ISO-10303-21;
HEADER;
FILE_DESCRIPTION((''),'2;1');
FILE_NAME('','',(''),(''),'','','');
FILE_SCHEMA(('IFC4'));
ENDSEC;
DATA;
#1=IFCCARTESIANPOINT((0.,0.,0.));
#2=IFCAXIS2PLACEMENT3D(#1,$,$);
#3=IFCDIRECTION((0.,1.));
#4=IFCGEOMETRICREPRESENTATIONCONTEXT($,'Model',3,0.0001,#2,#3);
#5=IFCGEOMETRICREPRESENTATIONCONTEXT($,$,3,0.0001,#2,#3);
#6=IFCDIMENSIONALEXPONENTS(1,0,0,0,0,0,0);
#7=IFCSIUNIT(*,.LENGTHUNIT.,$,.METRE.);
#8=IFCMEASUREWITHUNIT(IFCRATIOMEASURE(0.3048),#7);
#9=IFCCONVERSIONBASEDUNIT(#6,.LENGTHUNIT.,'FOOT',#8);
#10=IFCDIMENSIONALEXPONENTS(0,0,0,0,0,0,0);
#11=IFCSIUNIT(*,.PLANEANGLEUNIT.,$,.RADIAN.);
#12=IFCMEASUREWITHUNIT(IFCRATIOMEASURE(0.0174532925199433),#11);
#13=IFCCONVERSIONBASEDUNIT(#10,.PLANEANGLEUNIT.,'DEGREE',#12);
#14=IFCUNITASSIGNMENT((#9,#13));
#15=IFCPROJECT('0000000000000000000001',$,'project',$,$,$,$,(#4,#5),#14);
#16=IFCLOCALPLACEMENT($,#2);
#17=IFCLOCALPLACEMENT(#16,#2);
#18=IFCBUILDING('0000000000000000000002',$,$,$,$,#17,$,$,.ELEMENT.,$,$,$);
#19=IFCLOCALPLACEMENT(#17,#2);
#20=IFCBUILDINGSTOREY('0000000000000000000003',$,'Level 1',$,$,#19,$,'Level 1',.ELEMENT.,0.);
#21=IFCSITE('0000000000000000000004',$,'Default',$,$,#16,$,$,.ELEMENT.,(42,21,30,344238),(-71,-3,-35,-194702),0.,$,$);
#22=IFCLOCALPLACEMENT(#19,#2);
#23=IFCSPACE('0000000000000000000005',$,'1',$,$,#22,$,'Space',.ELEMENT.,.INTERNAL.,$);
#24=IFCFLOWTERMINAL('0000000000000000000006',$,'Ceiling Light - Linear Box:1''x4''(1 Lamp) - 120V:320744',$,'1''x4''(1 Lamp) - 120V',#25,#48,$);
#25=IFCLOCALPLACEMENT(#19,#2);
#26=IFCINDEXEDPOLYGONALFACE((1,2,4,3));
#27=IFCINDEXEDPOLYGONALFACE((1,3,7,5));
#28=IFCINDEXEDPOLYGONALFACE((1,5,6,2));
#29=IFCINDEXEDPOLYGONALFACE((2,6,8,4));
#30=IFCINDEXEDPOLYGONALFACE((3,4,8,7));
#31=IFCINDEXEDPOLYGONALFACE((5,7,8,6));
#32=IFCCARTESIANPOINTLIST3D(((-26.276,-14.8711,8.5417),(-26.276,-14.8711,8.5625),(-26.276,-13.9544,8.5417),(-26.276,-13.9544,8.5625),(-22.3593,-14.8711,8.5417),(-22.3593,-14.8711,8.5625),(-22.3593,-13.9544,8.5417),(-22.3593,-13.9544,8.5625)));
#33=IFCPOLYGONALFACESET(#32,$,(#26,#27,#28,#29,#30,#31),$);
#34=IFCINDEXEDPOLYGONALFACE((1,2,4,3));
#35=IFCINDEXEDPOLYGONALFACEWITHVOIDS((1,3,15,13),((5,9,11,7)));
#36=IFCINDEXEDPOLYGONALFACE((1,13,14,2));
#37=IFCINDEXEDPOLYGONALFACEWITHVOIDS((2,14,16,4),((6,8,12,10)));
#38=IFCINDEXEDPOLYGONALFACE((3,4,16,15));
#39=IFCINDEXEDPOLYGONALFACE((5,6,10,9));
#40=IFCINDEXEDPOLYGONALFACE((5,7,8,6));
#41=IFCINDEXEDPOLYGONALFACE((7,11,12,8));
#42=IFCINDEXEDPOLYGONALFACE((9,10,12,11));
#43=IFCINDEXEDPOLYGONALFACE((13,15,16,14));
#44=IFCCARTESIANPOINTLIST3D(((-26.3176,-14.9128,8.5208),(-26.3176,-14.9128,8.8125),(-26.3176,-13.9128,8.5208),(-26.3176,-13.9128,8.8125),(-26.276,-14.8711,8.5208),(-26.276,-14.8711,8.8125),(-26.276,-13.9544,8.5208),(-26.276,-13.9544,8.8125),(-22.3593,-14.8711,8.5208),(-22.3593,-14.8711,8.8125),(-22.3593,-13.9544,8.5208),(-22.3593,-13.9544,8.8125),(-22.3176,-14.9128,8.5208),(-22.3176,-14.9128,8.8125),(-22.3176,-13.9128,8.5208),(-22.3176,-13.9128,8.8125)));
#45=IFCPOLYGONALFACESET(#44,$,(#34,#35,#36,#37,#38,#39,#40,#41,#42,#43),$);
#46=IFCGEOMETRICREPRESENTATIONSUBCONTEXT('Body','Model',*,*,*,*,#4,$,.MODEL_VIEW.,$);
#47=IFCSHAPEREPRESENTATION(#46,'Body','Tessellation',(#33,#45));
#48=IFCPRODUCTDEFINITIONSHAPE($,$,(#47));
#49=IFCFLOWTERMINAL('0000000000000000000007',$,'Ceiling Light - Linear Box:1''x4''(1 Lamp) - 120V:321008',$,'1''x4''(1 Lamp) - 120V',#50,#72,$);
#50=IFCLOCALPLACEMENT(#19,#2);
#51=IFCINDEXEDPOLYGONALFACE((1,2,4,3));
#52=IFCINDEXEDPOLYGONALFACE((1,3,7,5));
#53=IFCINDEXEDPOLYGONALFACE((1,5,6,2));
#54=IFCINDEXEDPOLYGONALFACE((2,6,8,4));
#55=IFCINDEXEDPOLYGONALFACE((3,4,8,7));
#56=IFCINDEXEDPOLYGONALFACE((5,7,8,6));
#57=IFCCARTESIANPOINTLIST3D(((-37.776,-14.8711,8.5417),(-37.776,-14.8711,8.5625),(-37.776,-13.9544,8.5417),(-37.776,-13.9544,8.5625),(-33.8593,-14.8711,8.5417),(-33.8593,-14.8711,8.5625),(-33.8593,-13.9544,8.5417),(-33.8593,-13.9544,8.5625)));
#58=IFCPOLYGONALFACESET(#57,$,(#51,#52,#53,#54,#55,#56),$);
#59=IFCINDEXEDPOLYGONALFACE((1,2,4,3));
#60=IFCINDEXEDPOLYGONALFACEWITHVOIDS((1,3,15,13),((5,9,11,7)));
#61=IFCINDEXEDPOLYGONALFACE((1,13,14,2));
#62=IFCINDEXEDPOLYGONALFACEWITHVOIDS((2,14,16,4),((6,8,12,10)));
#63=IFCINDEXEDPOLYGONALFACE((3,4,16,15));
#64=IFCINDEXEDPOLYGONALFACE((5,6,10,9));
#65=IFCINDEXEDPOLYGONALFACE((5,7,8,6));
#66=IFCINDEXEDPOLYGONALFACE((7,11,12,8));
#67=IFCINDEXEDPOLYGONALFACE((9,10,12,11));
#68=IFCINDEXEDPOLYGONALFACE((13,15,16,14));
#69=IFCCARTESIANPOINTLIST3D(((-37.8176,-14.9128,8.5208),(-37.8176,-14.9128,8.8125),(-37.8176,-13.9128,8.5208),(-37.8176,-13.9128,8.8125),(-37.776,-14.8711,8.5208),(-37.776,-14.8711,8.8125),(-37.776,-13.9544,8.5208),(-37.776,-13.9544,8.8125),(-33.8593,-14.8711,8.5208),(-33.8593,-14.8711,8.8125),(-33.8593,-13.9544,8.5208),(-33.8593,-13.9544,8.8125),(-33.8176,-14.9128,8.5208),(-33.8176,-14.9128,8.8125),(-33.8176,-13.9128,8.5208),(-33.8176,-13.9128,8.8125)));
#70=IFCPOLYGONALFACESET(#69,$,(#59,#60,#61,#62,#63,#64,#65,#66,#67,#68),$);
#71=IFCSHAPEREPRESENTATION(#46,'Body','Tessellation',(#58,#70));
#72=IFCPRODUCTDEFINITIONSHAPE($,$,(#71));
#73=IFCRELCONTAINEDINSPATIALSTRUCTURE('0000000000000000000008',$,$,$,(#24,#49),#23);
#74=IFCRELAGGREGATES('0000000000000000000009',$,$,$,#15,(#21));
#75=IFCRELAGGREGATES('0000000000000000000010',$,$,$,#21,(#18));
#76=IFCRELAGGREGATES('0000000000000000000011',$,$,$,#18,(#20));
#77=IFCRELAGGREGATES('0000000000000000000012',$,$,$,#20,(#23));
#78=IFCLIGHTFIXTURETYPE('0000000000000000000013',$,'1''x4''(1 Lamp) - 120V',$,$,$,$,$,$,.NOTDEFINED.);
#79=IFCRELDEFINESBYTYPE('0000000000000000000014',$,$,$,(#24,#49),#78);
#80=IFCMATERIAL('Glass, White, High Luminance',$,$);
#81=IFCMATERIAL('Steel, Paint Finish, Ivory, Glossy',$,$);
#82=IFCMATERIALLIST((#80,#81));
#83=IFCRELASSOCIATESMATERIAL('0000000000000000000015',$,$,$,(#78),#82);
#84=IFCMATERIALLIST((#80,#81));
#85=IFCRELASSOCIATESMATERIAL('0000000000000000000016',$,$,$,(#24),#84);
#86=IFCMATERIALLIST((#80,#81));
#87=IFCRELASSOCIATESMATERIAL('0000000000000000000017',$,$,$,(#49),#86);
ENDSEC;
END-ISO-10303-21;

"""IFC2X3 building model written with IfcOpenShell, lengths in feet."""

from ifc_helpers import new_model, entity, si_unit, converted_unit, direction, frame, origin, origin_2d_with_axis, place, context, subcontext, project, spatial, polyline, rectangle, outline, extrude, source, transform, mapped, material, material_list, type_object, type_shapes, element, save


model = new_model("IFC2X3")

# Units and contexts
model_context = context("Model", 3, precision=0.0001, world=origin(), true_north=direction((0.0, 1.0)))
context_of_model = context(None, 3, precision=0.0001, world=origin(), true_north=direction((0.0, 1.0)))
body_context = subcontext(model_context, "Body", "Model", "MODEL_VIEW")
ifc_project = project(units=[converted_unit("LENGTHUNIT", "FOOT", entity("IfcRatioMeasure", 0.3048), si_unit("LENGTHUNIT", "METRE"), dimensions=[1, 0, 0, 0, 0, 0, 0]), converted_unit("PLANEANGLEUNIT", "DEGREE", entity("IfcRatioMeasure", 0.0174532925199433), si_unit("PLANEANGLEUNIT", "RADIAN"), dimensions=[0, 0, 0, 0, 0, 0, 0])], contexts=[model_context, context_of_model])

# Site, building, storey
site_placement = place(None, origin())
site = spatial("IfcSite", under=ifc_project, at=site_placement, Name="Default", CompositionType="ELEMENT", RefLatitude=(42, 21, 30, 344238), RefLongitude=(-71, -3, -35, -194702), RefElevation=0.0)
building_placement = place(site_placement, origin())
building = spatial("IfcBuilding", under=site, at=building_placement, CompositionType="ELEMENT")
storey_placement = place(building_placement, origin())
storey = spatial("IfcBuildingStorey", under=building, at=storey_placement, Name="Level 1", LongName="Level 1", CompositionType="ELEMENT", Elevation=0.0)

# Shared definitions
space_placement = place(storey_placement, origin())
space = spatial("IfcSpace", under=storey, at=space_placement, Name="1", LongName="Space", CompositionType="ELEMENT", InteriorOrExteriorSpace="INTERNAL")

# Flow terminals
ifc_material_1 = material(Name="Glass, White, High Luminance")
ifc_material_2 = material(Name="Steel, Paint Finish, Ivory, Glossy")
ifc_material_list_1 = material_list([ifc_material_1, ifc_material_2])
light_fixture_type = type_object("IfcLightFixtureType", Name="1'x4'(1 Lamp) - 120V", PredefinedType="NOTDEFINED", material=ifc_material_list_1)
shared_shape = source(origin(), body_context, "Body", "SweptSolid", [
    extrude(rectangle(XDim=3.9167, YDim=0.9167, at=origin_2d_with_axis()), frame((0.0, 0.0, 7.7292), z_axis=(0.0, 0.0, 1.0), x_axis=(-1.0, 0.0, 0.0)), (0.0, 0.0, 1.0), 0.0208),
    extrude(outline(polyline([(-2.0, -0.5), (2.0, -0.5), (2.0, 0.5), (-2.0, 0.5), (-2.0, -0.5)]), holes=[polyline([(-1.9583, -0.4583), (-1.9583, 0.4583), (1.9583, 0.4583), (1.9583, -0.4583), (-1.9583, -0.4583)])]), frame((0.0, 0.0, 7.7083), z_axis=(0.0, 0.0, 1.0), x_axis=(-1.0, 0.0, 0.0)), (0.0, 0.0, 1.0), 0.2917),
])
type_shapes(light_fixture_type, [shared_shape])
ifc_material_list_2 = material_list([ifc_material_1, ifc_material_2])
flow_terminal_1_placement = place(space_placement, frame((-24.3176, -14.4128, 0.8125)))
element("IfcFlowTerminal", 1, at=flow_terminal_1_placement, inside=space, type_object=light_fixture_type, material=ifc_material_list_2, Name="Ceiling Light - Linear Box:1'x4'(1 Lamp) - 120V:320744", ObjectType="1'x4'(1 Lamp) - 120V", context=body_context, shape_type="MappedRepresentation", body=[
    mapped(shared_shape, transform((0.0, 0.0, 0.0), scale=1.0)),
])
ifc_material_list_3 = material_list([ifc_material_1, ifc_material_2])
flow_terminal_2_placement = place(space_placement, frame((-35.8176, -14.4128, 0.8125)))
element("IfcFlowTerminal", 2, at=flow_terminal_2_placement, inside=space, type_object=light_fixture_type, material=ifc_material_list_3, Name="Ceiling Light - Linear Box:1'x4'(1 Lamp) - 120V:321008", ObjectType="1'x4'(1 Lamp) - 120V", context=body_context, shape_type="MappedRepresentation", body=[
    mapped(shared_shape, transform((0.0, 0.0, 0.0), scale=1.0)),
])

save(model, "model.ifc")
